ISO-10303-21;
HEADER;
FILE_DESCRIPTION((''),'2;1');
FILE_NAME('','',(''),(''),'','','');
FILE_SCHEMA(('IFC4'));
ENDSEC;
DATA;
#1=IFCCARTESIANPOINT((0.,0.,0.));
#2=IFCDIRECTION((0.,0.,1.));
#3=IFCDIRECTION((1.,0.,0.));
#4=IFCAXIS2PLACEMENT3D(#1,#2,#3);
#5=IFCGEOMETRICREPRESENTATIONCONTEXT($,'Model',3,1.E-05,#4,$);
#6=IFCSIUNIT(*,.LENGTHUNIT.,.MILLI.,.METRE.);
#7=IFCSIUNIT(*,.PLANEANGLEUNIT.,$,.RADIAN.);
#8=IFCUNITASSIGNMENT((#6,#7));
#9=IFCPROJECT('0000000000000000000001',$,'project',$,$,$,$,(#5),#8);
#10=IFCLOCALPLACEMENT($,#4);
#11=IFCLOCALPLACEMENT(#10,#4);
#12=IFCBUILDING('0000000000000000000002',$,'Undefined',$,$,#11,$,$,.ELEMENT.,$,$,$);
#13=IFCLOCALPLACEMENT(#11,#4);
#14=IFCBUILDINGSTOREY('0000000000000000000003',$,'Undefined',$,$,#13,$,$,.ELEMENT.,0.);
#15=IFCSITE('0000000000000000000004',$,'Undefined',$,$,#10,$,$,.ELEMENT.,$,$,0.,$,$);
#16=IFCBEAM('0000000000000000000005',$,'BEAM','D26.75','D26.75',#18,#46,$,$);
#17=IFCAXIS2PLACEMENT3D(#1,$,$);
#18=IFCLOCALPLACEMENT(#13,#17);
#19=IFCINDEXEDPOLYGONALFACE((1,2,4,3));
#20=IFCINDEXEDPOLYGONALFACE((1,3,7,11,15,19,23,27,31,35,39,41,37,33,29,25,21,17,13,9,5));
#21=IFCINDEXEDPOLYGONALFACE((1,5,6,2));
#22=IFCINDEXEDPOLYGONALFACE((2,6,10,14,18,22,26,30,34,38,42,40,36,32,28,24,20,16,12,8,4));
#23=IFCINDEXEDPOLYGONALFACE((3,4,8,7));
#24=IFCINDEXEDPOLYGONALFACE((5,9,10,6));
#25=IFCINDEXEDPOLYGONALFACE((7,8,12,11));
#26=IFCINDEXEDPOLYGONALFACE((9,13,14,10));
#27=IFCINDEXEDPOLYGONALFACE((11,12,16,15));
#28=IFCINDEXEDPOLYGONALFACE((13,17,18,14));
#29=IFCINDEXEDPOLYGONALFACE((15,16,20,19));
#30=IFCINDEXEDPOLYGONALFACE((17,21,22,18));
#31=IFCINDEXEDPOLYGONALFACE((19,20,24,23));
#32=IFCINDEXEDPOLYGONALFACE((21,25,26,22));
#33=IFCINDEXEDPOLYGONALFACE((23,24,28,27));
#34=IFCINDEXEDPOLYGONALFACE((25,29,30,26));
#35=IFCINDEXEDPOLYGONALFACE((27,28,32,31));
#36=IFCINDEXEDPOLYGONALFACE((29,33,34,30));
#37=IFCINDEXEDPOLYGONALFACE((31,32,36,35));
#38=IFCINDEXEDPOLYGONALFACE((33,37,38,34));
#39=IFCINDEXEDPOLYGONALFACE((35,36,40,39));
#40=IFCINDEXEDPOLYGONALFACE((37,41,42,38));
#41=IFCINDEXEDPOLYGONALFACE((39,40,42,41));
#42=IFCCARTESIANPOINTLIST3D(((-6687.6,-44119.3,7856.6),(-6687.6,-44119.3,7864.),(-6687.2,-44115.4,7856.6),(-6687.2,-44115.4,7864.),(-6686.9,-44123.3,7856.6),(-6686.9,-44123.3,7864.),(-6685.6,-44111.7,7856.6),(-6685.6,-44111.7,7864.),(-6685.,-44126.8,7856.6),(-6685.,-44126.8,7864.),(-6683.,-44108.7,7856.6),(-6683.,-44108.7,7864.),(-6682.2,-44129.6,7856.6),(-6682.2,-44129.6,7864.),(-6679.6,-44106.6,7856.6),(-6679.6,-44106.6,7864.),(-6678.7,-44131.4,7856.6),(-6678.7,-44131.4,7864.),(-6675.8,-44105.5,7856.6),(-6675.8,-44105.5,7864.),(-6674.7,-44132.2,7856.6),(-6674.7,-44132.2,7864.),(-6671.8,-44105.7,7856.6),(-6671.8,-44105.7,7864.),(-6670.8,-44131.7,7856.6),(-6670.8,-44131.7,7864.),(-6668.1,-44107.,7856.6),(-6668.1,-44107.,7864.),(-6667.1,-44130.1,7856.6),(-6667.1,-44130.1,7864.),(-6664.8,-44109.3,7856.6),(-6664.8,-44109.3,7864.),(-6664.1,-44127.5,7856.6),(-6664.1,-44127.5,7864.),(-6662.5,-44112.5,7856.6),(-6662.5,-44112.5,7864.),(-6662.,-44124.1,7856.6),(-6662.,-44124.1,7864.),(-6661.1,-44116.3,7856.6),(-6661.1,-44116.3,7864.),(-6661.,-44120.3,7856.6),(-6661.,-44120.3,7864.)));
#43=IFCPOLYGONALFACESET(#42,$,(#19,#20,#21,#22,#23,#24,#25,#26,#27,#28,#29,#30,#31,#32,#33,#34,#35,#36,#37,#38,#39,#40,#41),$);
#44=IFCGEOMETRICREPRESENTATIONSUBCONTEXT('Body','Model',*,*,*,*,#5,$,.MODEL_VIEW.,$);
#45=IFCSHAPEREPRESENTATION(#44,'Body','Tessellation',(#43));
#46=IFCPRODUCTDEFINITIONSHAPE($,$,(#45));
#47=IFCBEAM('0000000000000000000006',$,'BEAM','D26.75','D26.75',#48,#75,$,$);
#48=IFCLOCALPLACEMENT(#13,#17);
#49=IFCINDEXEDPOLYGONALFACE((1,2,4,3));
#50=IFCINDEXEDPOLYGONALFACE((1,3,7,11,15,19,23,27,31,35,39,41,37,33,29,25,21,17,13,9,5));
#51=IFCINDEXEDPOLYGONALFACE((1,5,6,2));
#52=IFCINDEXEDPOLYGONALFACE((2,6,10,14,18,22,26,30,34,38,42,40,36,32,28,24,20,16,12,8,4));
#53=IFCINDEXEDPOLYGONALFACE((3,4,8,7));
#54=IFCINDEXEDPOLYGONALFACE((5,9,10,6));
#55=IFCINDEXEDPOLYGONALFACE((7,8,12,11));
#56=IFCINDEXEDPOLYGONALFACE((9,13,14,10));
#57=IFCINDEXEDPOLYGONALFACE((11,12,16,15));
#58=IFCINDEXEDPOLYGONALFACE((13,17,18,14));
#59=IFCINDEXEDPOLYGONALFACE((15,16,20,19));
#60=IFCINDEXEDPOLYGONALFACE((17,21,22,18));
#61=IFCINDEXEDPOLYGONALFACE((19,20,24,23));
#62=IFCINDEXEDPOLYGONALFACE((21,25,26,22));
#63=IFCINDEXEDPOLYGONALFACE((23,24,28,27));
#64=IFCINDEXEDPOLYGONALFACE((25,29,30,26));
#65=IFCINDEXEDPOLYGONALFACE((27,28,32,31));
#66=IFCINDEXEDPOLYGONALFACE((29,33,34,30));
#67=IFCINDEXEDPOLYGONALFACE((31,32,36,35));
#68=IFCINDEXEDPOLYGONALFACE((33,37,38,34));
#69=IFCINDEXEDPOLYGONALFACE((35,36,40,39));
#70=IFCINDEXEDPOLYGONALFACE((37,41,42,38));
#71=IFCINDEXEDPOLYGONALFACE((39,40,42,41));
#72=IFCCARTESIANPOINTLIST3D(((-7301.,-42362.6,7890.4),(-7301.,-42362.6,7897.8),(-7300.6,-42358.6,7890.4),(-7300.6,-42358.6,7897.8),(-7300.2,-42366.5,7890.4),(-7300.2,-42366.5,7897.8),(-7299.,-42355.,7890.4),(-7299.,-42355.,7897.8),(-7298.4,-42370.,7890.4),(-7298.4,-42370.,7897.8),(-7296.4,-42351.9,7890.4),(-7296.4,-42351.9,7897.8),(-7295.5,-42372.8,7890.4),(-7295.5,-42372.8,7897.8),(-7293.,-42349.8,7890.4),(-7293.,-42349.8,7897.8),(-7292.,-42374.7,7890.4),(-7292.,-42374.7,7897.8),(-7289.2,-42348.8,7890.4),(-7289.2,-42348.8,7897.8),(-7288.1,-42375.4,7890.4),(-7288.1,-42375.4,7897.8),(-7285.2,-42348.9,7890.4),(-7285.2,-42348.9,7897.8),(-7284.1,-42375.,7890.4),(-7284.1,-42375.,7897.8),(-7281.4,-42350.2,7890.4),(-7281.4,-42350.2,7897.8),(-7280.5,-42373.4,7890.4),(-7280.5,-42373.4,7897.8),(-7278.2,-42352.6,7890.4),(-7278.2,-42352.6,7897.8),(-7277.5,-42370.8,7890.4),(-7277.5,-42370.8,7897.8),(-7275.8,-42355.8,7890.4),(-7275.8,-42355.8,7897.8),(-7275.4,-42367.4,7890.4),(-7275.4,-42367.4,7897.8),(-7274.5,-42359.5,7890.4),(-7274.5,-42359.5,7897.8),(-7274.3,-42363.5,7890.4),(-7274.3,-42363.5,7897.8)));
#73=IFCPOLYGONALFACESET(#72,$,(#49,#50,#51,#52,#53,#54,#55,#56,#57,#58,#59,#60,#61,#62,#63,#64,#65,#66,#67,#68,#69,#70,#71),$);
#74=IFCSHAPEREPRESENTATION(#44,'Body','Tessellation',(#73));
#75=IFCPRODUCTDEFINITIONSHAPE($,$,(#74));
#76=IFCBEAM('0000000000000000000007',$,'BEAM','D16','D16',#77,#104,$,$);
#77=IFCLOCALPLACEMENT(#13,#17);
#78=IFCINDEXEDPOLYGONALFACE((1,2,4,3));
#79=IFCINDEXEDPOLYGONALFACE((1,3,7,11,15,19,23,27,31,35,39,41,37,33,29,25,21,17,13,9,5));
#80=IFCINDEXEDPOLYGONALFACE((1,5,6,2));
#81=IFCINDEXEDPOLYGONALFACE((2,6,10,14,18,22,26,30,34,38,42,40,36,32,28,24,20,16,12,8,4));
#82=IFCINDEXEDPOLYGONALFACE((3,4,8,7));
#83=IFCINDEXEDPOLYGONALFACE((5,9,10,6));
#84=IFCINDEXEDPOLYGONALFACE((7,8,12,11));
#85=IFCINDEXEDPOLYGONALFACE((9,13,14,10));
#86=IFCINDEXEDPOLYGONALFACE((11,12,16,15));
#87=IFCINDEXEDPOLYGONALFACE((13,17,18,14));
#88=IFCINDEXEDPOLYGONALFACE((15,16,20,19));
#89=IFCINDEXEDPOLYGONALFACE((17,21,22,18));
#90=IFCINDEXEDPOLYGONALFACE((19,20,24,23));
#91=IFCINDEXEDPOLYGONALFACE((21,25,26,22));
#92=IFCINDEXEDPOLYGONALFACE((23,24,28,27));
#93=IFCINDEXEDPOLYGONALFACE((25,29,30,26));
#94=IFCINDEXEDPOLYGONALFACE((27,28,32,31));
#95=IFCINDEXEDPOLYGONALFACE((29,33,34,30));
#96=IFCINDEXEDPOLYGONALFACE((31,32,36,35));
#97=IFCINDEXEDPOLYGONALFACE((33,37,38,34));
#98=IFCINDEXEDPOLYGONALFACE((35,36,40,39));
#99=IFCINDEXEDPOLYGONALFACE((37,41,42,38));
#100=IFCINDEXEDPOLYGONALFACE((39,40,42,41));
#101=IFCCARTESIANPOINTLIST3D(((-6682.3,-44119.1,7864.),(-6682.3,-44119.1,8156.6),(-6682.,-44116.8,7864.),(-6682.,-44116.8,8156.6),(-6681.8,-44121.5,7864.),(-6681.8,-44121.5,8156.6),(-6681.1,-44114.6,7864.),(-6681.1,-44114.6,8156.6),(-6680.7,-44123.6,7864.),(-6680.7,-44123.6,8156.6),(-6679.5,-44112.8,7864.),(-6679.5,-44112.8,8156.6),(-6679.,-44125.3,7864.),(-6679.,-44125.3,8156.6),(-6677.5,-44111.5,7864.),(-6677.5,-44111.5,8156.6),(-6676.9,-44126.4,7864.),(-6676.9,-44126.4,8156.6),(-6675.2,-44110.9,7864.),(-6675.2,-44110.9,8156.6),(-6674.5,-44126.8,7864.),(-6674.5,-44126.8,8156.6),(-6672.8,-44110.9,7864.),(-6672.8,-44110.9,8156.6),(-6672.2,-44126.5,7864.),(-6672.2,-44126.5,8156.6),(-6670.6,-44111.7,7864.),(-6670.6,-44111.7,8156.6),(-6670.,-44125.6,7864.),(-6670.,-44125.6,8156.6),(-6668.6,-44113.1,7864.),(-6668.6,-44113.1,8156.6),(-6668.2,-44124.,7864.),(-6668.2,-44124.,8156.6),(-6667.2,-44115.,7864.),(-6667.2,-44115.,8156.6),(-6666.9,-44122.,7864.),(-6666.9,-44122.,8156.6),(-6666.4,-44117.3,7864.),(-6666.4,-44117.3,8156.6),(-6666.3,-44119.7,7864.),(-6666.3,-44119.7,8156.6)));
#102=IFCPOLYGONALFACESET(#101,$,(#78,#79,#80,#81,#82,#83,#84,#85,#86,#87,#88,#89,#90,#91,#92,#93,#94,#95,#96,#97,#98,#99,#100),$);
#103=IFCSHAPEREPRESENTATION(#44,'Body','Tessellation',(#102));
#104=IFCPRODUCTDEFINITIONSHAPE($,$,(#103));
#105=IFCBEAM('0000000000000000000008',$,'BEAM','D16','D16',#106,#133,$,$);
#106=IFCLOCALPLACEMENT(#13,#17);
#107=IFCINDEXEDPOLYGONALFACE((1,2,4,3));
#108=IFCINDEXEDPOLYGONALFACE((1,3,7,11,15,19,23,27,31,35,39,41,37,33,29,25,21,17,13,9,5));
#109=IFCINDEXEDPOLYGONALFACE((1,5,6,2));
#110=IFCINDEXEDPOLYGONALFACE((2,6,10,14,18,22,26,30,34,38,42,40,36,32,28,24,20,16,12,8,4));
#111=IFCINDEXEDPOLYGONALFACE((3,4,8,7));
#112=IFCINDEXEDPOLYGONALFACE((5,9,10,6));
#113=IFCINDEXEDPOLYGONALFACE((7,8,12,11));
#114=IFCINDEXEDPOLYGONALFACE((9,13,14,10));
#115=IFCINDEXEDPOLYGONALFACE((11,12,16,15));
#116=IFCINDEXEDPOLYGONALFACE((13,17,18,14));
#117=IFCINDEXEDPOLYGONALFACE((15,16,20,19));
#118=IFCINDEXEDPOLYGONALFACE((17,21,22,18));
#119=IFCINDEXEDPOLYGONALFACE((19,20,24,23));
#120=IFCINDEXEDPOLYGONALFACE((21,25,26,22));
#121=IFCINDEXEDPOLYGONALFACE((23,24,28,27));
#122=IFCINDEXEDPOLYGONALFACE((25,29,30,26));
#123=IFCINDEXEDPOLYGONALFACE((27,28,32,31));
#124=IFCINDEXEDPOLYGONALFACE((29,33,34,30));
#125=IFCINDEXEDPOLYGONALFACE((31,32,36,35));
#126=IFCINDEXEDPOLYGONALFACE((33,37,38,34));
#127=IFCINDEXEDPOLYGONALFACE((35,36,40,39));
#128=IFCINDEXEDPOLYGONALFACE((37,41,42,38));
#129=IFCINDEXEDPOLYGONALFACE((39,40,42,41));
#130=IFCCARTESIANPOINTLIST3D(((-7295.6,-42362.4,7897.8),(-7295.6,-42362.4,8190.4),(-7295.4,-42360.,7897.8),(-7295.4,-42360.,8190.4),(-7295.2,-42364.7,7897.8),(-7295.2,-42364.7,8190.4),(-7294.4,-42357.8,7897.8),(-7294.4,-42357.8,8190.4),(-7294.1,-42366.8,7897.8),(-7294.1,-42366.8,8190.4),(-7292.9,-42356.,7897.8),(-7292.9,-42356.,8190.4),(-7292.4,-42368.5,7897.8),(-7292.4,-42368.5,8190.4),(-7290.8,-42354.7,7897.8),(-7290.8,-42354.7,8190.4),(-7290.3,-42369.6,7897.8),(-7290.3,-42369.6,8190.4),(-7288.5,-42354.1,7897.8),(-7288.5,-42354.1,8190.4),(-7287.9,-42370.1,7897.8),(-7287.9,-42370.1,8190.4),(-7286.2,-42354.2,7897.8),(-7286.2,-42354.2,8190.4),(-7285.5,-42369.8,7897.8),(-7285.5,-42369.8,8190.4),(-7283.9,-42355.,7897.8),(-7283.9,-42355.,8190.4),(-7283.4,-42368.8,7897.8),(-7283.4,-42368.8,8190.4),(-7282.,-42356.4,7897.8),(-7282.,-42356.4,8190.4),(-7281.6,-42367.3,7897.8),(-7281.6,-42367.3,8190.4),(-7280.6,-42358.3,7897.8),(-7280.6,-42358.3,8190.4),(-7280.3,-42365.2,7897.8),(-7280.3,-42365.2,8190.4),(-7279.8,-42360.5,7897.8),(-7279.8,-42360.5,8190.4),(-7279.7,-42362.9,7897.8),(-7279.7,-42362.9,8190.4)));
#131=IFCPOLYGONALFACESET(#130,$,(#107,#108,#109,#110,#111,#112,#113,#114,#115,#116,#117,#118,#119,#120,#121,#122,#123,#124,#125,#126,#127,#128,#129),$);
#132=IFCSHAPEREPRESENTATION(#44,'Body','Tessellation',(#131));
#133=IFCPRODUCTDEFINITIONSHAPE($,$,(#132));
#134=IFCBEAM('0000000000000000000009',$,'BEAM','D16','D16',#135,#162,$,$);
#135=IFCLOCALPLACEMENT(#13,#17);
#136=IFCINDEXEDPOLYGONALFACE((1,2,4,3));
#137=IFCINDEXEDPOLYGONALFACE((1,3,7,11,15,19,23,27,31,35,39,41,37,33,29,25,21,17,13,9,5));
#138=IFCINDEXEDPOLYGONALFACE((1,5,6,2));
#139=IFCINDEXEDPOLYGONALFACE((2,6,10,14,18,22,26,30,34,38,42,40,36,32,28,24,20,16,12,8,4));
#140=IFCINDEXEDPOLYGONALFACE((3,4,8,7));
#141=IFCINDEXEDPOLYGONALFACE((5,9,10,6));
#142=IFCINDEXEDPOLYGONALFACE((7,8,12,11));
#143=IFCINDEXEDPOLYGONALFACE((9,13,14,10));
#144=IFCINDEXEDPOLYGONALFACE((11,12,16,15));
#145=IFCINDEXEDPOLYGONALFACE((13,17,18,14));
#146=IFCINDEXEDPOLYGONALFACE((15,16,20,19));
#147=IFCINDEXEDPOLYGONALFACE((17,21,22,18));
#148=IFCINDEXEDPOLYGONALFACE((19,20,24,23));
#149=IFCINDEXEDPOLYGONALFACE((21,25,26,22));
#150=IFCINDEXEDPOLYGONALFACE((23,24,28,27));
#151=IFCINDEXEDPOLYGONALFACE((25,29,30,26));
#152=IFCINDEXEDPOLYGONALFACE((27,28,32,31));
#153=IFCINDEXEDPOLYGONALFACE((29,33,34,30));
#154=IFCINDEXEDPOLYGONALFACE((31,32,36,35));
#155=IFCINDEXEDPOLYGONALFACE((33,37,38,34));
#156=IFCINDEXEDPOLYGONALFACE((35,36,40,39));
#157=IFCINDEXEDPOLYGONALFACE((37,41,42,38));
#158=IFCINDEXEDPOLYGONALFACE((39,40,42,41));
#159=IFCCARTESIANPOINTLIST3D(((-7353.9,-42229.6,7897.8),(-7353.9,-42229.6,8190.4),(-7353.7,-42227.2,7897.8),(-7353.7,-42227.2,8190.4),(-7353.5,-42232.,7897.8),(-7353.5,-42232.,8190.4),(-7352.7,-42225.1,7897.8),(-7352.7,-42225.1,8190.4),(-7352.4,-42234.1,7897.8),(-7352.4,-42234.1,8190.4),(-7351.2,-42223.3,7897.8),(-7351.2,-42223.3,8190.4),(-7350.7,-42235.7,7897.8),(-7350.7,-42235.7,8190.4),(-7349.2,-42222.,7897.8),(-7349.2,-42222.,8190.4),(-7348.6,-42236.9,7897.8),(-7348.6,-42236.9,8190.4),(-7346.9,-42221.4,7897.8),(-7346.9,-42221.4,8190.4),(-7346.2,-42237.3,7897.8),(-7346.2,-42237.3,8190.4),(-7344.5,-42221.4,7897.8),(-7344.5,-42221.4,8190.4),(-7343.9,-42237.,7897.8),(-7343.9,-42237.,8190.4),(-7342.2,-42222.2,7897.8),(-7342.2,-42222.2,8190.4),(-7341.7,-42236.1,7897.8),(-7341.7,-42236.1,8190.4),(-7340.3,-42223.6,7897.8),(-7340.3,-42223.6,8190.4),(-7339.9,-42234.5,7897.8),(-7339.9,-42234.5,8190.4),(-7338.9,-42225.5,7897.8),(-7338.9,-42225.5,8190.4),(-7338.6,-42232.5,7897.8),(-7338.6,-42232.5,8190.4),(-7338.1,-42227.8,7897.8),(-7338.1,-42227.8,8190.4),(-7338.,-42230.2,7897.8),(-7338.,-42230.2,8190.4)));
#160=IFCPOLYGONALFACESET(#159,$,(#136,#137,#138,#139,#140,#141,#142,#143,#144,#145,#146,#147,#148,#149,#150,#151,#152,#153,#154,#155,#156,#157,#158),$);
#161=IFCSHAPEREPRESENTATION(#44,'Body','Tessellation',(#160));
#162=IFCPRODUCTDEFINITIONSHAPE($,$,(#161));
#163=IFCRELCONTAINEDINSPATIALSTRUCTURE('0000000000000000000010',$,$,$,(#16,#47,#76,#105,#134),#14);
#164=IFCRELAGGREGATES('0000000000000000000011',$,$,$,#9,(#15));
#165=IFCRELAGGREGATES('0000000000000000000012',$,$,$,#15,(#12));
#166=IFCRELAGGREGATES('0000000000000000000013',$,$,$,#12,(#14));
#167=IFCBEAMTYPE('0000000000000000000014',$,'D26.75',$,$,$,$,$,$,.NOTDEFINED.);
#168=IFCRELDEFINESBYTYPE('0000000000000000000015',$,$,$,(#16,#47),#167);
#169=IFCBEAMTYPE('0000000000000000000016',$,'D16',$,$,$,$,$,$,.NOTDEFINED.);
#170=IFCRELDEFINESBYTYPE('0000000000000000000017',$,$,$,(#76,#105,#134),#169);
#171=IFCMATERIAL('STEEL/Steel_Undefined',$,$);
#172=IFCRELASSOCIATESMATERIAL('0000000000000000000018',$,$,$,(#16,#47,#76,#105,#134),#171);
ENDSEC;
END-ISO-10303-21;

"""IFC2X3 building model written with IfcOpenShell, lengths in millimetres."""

from ifc_helpers import new_model, si_unit, frame, origin_with_axes, origin_2d_with_axis, place, context, subcontext, project, spatial, circle, extrude, material, type_object, element, save


model = new_model("IFC2X3")

# Units and contexts
model_context = context("Model", 3, precision=1e-05, world=origin_with_axes())
body_context = subcontext(model_context, "Body", "Model", "MODEL_VIEW")
ifc_project = project(units=[si_unit("LENGTHUNIT", "METRE", prefix="MILLI"), si_unit("PLANEANGLEUNIT", "RADIAN")], contexts=[model_context])

# Site, building, storey
site_placement = place(None, origin_with_axes())
site = spatial("IfcSite", under=ifc_project, at=site_placement, Name="Undefined", CompositionType="ELEMENT", RefElevation=0.0)
building_placement = place(site_placement, origin_with_axes())
building = spatial("IfcBuilding", under=site, at=building_placement, Name="Undefined", CompositionType="ELEMENT")
storey_placement = place(building_placement, origin_with_axes())
storey = spatial("IfcBuildingStorey", under=building, at=storey_placement, Name="Undefined", CompositionType="ELEMENT", Elevation=0.0)

# Shared definitions
ifc_material = material(Name="STEEL/Steel_Undefined")
beam_type_1 = type_object("IfcBeamType", Name="D26.75", PredefinedType="NOTDEFINED")

# Beam
beam_1_placement = place(storey_placement, frame((-6674.3, -44118.8, 7864.0), z_axis=(-0.915553, -0.402198, 0.0), x_axis=(0.0, 0.0, -1.0)))
element("IfcBeam", 1, at=beam_1_placement, inside=storey, type_object=beam_type_1, material=ifc_material, Name="BEAM", Description="D26.75", ObjectType="D26.75", context=body_context, shape_type="SweptSolid", body=[
    extrude(circle(Radius=13.4, at=origin_2d_with_axis()), frame((7.4, 0.0, 0.0), z_axis=(-1.0, 0.0, 0.0), x_axis=(0.0, -1.0, 0.0)), (0.0, 0.0, 1.0), 7.4),
])

# Beam
beam_2_placement = place(storey_placement, frame((-7287.6, -42362.1, 7897.8), z_axis=(-0.915553, -0.402198, 0.0), x_axis=(0.0, 0.0, -1.0)))
element("IfcBeam", 2, at=beam_2_placement, inside=storey, type_object=beam_type_1, material=ifc_material, Name="BEAM", Description="D26.75", ObjectType="D26.75", context=body_context, shape_type="SweptSolid", body=[
    extrude(circle(Radius=13.4, at=origin_2d_with_axis()), frame((7.4, 0.0, 0.0), z_axis=(-1.0, 0.0, 0.0), x_axis=(0.0, -1.0, 0.0)), (0.0, 0.0, 1.0), 7.4),
])

# Beams
beam_type_2 = type_object("IfcBeamType", Name="D16", PredefinedType="NOTDEFINED")
for number, where, z_axis, x_axis, name in (
    (3, (-6674.3, -44118.8, 8156.6), (-0.915553, -0.402198, 0.0), (0.0, 0.0, -1.0), "BEAM"),
    (4, (-7287.6, -42362.1, 8190.4), (-0.915553, -0.402198, 0.0), (0.0, 0.0, -1.0), "BEAM"),
    (5, (-7345.9, -42229.3, 8190.4), (-0.915553, -0.402198, 0.0), (0.0, 0.0, -1.0), "BEAM"),
):
    element("IfcBeam", number, at=place(storey_placement, frame(where, z_axis=z_axis, x_axis=x_axis)), inside=storey, type_object=beam_type_2, material=ifc_material, Name=name, Description="D16", ObjectType="D16", context=body_context, shape_type="SweptSolid", body=[
        extrude(circle(Radius=8.0, at=origin_2d_with_axis()), frame((292.6, 0.0, 0.0), z_axis=(-1.0, 0.0, 0.0), x_axis=(0.0, -1.0, 0.0)), (0.0, 0.0, 1.0), 292.6),
    ])

save(model, "model.ifc")
